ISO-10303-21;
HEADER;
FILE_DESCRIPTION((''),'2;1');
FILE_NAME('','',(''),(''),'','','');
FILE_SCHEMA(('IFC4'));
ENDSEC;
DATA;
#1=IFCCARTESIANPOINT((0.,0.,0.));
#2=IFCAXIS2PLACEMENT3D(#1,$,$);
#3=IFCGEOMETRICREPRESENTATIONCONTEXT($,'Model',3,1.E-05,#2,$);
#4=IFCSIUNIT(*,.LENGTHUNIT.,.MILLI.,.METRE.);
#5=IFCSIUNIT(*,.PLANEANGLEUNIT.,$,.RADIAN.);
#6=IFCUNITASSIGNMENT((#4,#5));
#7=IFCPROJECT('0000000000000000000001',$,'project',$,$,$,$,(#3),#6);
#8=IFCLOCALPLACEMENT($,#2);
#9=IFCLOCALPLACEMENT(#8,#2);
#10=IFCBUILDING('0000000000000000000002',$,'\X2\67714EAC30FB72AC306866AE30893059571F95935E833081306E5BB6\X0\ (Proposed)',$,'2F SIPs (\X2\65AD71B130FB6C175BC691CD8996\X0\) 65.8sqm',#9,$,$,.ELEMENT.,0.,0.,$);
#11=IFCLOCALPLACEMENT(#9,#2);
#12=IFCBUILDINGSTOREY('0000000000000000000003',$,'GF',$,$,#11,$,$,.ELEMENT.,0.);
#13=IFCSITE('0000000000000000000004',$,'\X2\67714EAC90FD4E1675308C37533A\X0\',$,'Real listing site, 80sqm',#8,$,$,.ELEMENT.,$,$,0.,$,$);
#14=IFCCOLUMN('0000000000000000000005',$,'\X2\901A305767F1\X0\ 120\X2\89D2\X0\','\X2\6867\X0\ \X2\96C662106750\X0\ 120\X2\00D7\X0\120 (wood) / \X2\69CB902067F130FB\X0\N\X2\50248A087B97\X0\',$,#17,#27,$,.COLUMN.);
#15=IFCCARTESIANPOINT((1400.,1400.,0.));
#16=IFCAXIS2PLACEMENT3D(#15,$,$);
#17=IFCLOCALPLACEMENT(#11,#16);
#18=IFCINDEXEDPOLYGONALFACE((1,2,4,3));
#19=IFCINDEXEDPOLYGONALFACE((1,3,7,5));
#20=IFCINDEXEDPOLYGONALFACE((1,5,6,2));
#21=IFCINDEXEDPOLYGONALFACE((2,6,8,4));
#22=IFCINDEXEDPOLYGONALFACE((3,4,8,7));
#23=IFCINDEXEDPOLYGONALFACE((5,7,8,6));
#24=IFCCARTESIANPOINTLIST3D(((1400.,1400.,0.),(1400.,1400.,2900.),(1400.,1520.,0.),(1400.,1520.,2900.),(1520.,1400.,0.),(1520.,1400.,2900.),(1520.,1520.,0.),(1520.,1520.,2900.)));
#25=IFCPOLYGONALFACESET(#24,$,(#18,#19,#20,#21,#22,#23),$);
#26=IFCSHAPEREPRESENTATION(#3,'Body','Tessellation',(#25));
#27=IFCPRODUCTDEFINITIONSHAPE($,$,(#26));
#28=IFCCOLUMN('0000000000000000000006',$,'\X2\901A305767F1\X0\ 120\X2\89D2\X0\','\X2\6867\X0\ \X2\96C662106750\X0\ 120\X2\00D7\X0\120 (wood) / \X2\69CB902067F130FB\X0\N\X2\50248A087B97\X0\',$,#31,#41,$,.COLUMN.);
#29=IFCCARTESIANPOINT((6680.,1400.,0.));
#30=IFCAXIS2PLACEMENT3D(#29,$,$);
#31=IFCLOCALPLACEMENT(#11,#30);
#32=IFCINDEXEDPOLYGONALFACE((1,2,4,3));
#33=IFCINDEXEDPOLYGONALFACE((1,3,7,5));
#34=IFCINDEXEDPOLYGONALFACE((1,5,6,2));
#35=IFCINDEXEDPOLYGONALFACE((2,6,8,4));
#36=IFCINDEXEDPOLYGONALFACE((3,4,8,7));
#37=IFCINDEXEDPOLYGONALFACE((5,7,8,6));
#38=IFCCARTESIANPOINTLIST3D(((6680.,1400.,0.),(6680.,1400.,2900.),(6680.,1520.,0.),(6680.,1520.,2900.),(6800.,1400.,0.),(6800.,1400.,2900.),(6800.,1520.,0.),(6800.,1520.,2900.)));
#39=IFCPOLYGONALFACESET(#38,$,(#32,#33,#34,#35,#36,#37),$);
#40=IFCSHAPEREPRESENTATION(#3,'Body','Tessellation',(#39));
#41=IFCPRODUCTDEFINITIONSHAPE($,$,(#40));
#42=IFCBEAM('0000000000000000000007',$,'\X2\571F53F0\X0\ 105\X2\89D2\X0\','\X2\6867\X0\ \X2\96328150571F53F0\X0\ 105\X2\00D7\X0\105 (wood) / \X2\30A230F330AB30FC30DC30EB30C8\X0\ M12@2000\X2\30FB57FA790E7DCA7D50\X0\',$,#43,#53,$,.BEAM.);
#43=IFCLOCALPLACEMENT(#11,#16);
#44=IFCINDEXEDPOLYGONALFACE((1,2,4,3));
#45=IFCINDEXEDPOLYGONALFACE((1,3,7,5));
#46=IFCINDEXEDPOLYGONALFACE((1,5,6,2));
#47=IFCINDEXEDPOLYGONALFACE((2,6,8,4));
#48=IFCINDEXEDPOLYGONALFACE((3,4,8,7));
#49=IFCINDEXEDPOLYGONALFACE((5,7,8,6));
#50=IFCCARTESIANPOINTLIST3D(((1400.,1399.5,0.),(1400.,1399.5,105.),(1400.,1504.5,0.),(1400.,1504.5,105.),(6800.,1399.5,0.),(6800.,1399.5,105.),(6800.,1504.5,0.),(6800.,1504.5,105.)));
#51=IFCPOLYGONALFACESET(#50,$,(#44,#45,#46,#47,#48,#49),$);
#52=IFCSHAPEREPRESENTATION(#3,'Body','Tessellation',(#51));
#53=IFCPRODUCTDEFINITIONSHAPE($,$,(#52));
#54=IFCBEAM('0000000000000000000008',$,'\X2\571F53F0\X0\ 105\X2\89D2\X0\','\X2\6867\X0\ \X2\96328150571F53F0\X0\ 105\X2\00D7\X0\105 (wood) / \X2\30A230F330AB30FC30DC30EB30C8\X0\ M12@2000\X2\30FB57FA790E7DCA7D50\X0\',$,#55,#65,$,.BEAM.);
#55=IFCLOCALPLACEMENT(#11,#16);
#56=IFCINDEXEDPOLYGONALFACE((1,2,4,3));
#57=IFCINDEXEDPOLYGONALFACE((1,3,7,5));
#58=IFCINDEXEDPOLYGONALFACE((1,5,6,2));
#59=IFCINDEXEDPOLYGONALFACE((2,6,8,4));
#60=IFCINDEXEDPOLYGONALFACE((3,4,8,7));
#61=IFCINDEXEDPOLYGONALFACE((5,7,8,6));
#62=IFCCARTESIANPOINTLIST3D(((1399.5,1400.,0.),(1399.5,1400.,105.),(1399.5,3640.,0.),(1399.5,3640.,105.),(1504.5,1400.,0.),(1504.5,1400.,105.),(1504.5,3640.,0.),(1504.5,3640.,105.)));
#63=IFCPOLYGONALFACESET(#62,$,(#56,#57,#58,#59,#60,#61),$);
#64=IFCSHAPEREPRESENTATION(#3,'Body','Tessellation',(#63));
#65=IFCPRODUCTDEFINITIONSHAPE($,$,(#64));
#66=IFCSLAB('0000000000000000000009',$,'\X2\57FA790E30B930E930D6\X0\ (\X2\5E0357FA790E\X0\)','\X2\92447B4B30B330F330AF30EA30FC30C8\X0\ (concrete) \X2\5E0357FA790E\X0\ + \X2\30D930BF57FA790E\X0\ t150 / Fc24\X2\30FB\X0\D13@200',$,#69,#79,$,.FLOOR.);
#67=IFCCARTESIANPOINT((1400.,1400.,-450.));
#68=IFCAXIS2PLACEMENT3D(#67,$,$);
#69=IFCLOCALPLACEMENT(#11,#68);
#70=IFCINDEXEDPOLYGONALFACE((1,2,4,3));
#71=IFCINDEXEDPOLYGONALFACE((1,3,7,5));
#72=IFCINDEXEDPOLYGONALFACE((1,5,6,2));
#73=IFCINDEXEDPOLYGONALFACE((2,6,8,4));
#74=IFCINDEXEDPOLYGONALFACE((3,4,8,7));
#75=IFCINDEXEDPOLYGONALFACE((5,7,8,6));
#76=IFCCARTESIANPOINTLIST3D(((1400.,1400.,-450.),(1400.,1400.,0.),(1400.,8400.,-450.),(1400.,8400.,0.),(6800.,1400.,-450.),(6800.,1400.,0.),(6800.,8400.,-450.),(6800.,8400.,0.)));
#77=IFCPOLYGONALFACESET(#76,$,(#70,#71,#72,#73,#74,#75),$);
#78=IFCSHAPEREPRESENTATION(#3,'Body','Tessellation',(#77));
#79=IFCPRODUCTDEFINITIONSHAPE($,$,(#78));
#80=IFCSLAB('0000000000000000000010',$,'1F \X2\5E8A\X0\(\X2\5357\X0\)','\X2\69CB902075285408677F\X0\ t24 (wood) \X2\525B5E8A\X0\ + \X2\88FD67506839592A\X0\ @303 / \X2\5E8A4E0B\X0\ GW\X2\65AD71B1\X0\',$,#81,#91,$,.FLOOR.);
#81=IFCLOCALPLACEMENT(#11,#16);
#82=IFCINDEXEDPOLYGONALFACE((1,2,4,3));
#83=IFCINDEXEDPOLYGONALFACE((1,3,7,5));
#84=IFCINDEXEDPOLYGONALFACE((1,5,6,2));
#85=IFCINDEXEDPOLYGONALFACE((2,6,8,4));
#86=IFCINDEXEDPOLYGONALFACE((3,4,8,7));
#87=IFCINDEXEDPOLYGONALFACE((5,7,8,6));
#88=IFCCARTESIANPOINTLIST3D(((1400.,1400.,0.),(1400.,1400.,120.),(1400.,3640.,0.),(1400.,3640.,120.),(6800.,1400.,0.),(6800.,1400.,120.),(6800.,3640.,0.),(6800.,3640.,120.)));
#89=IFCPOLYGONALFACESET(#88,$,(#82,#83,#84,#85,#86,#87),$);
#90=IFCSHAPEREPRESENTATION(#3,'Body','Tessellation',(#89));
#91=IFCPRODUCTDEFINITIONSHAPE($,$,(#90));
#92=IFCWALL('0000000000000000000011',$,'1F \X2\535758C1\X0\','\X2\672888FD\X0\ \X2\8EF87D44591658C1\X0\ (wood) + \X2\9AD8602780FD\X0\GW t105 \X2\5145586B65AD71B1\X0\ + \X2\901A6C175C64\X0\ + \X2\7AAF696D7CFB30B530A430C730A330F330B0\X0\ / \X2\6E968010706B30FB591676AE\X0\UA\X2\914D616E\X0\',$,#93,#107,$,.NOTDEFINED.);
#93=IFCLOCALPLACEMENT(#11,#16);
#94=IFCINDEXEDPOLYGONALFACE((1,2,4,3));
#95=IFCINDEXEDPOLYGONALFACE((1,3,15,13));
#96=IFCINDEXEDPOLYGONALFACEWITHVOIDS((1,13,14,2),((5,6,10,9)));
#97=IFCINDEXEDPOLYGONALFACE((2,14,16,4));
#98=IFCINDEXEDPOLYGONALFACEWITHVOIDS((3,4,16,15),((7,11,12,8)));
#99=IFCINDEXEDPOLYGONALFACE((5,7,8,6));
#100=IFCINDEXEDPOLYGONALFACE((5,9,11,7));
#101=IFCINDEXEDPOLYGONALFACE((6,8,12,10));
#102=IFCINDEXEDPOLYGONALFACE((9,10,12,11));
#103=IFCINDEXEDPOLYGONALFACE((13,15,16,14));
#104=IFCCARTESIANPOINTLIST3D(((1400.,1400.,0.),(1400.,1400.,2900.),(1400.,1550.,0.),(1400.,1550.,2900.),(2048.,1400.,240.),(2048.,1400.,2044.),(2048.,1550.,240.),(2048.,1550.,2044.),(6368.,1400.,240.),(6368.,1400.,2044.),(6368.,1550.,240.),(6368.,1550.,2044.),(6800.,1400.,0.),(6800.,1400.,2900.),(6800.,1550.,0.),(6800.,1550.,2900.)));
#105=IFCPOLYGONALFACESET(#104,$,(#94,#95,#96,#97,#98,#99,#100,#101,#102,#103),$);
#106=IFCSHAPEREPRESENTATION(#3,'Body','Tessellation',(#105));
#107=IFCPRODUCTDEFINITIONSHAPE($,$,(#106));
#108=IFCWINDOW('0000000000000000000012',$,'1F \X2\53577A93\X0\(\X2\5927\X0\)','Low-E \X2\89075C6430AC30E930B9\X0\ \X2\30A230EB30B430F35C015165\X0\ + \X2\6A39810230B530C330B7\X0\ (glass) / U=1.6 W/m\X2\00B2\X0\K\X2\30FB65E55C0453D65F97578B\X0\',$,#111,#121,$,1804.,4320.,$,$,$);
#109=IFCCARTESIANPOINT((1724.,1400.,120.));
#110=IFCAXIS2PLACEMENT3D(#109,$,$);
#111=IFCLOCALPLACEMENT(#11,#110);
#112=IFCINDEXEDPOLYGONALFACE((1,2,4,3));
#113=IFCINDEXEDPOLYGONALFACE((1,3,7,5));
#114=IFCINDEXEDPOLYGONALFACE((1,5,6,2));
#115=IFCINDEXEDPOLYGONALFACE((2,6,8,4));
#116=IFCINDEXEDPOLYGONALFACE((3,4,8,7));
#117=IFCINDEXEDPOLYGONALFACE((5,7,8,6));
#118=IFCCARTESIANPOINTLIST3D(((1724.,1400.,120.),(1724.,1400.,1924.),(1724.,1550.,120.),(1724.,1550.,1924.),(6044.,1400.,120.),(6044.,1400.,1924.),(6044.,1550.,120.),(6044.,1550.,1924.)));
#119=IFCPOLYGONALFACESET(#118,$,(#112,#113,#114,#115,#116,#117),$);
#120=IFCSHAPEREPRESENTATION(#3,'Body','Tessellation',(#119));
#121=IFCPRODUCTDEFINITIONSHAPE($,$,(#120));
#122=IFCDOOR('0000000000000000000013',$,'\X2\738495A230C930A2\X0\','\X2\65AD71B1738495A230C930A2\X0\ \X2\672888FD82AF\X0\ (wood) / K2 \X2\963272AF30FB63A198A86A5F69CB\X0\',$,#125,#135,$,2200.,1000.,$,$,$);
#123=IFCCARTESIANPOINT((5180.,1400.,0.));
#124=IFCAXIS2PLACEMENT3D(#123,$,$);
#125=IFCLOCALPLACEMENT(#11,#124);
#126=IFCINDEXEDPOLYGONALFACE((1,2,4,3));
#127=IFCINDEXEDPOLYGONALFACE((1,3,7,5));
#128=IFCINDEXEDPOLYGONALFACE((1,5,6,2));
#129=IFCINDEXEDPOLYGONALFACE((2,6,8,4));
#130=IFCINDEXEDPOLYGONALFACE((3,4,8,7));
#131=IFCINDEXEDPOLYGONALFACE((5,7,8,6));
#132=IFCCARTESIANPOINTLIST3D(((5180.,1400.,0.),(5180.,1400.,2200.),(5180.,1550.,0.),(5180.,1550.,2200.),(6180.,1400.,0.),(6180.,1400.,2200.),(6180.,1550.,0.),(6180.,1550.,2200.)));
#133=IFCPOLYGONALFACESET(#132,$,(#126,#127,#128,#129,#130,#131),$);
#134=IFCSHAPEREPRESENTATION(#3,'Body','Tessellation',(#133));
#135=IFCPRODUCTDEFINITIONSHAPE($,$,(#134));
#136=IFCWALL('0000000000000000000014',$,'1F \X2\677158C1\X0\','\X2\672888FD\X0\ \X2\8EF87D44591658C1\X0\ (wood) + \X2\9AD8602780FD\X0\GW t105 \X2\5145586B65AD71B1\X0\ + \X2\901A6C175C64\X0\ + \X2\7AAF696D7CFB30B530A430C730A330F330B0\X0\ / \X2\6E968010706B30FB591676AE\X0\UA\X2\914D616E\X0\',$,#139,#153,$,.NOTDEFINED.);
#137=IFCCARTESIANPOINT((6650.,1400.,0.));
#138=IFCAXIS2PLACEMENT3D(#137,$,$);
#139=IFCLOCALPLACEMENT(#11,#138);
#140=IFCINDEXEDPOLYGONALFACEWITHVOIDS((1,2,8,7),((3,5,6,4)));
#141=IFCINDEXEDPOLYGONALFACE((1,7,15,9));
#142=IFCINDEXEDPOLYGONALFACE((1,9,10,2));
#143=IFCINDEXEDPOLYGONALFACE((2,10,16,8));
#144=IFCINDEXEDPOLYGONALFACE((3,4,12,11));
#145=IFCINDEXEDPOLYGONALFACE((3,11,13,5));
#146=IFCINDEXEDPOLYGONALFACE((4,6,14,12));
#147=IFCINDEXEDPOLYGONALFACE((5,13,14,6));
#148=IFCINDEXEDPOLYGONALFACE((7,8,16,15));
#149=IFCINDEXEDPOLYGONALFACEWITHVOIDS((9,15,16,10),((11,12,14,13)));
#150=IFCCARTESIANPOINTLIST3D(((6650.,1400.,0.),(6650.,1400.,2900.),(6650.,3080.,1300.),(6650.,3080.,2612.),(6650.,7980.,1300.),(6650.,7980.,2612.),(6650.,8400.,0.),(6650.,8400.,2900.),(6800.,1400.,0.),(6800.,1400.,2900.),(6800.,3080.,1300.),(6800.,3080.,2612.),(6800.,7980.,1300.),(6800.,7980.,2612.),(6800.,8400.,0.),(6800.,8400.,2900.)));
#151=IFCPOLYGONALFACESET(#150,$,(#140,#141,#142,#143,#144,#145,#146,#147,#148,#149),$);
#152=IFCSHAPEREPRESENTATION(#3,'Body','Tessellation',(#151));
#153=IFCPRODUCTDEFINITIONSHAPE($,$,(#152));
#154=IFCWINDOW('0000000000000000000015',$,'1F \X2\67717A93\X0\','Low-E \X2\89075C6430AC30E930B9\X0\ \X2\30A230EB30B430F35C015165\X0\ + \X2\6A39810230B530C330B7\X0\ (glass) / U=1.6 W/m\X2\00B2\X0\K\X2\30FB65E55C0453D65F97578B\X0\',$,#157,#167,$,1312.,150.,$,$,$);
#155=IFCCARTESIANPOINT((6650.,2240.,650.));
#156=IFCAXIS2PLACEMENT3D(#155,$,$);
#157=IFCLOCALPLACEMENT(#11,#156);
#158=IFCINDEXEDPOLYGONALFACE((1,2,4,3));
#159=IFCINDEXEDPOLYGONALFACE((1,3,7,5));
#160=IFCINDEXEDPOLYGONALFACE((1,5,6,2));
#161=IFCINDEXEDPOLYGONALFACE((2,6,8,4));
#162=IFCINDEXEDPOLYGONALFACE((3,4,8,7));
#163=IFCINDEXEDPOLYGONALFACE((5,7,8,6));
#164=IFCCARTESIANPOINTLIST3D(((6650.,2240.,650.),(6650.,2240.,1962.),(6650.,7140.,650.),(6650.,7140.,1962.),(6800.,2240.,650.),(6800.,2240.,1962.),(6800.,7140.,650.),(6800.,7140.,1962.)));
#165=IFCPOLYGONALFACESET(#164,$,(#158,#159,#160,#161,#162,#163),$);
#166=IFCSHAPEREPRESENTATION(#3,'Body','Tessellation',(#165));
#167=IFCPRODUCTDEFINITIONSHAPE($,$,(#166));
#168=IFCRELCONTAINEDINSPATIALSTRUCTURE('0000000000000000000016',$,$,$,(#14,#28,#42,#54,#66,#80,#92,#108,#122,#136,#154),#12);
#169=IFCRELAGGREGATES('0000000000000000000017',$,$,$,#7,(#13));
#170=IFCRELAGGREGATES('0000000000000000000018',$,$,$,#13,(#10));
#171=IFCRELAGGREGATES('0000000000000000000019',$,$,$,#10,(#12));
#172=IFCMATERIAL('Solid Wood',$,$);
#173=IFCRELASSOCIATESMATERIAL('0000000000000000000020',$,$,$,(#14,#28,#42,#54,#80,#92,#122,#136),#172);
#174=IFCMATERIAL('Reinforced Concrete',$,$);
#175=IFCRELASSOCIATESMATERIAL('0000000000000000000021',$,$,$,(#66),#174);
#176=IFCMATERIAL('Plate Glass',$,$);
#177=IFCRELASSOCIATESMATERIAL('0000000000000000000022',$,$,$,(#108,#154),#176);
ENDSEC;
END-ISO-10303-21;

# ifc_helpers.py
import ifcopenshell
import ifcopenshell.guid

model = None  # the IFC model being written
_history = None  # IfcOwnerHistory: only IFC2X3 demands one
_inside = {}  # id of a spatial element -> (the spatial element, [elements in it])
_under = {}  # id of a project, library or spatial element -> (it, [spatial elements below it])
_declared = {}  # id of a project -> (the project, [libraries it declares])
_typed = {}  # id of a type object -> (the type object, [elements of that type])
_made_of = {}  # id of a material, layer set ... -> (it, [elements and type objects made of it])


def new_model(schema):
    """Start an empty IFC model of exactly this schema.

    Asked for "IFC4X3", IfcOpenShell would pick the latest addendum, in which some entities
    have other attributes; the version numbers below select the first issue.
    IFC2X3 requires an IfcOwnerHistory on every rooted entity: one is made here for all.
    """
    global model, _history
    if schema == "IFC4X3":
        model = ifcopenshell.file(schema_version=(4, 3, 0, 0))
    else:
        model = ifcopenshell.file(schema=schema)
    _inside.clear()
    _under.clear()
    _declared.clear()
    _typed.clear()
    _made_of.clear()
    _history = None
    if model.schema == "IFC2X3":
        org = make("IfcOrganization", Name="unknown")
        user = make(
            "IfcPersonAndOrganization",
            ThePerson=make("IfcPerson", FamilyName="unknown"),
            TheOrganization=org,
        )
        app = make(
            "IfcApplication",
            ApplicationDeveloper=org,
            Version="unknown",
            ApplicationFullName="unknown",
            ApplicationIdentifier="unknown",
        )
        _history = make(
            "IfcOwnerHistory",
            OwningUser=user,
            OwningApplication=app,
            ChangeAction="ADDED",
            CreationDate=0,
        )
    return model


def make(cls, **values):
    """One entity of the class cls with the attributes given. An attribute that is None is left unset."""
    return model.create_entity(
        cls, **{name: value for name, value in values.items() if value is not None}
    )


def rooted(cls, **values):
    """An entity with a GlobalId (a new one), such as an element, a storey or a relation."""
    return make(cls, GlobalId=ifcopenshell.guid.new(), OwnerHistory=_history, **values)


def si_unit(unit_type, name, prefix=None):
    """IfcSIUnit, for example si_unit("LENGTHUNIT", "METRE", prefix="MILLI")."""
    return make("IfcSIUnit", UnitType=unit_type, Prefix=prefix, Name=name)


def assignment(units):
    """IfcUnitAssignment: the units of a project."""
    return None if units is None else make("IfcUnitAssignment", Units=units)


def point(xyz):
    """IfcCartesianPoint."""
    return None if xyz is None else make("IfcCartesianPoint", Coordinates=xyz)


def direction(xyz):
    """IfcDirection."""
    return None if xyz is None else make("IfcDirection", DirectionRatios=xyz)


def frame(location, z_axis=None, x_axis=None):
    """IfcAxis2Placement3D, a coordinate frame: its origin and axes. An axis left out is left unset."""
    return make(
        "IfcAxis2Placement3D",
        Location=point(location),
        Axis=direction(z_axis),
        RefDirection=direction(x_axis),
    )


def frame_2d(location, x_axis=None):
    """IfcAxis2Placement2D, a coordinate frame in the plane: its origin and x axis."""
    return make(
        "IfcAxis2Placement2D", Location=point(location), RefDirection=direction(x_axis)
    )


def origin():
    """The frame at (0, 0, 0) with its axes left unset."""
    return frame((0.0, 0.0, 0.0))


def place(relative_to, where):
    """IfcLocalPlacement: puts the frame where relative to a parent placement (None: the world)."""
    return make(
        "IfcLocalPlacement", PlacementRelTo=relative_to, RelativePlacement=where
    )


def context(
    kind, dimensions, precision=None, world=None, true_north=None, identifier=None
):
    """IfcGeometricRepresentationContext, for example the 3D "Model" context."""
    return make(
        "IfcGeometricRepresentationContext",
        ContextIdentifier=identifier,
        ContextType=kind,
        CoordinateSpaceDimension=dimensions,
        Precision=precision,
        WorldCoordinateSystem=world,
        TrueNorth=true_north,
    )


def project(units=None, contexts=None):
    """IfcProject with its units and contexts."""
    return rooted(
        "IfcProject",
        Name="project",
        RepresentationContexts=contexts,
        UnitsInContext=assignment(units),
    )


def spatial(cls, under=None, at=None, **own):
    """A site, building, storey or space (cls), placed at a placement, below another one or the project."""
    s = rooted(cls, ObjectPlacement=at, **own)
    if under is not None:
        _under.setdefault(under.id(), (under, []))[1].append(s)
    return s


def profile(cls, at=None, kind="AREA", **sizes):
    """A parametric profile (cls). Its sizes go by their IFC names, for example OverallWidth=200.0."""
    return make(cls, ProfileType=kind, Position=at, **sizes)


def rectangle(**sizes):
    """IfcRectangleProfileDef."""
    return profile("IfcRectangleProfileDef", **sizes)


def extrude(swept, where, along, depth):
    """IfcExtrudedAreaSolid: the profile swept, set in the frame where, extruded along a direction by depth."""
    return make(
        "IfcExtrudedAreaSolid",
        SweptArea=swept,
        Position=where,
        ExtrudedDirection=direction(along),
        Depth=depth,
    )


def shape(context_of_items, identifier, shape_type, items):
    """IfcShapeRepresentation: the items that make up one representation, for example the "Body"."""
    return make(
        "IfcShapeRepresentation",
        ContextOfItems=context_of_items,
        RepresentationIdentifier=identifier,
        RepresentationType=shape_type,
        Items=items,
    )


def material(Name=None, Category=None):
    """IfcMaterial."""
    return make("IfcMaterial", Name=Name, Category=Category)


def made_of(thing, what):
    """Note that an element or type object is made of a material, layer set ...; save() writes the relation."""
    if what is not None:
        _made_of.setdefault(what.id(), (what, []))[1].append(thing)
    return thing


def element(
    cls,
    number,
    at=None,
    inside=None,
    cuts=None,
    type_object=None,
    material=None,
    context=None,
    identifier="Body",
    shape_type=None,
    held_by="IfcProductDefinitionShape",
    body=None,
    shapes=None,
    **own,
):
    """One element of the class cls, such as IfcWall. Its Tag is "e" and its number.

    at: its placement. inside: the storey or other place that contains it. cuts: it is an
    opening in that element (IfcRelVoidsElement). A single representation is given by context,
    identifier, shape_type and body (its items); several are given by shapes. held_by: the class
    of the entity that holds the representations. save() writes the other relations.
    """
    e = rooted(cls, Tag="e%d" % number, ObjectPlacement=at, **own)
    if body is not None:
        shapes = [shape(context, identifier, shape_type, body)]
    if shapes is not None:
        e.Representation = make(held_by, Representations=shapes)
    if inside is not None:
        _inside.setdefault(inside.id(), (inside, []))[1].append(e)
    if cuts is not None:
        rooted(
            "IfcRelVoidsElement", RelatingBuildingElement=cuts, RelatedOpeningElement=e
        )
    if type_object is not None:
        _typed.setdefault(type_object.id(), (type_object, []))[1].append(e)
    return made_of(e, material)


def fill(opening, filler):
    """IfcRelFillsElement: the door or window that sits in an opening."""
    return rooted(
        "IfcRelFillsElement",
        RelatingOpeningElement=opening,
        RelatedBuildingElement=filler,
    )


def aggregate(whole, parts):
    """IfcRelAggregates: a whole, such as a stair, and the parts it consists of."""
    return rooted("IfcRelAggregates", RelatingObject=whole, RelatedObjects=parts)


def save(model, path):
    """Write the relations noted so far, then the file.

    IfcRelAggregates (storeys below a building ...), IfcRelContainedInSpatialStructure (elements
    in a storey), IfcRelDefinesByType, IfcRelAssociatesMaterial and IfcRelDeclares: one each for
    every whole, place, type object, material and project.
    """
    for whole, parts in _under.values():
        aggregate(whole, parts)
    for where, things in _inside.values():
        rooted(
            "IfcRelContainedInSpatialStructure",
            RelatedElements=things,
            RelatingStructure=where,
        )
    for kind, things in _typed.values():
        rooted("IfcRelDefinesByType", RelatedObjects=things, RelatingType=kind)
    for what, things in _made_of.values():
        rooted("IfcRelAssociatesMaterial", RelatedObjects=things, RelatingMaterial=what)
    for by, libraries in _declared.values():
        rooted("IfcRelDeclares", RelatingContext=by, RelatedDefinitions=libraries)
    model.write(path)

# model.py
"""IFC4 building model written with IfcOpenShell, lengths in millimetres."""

from ifc_helpers import new_model, si_unit, frame, frame_2d, origin, place, context, project, spatial, rectangle, extrude, material, element, fill, save


model = new_model("IFC4")

# Units and contexts
model_context = context("Model", 3, precision=1e-05, world=origin())
ifc_project = project(units=[si_unit("LENGTHUNIT", "METRE", prefix="MILLI"), si_unit("PLANEANGLEUNIT", "RADIAN")], contexts=[model_context])

# Site, building, storey
site_placement = place(None, origin())
site = spatial("IfcSite", under=ifc_project, at=site_placement, Name="東京都世田谷区", ObjectType="Real listing site, 80sqm", CompositionType="ELEMENT", RefElevation=0.0)
building_placement = place(site_placement, origin())
building = spatial("IfcBuilding", under=site, at=building_placement, Name="東京・犬と暮らす土間広めの家 (Proposed)", ObjectType="2F SIPs (断熱・気密重視) 65.8sqm", CompositionType="ELEMENT", ElevationOfRefHeight=0.0, ElevationOfTerrain=0.0)
storey_placement = place(building_placement, origin())
storey = spatial("IfcBuildingStorey", under=building, at=storey_placement, Name="GF", CompositionType="ELEMENT", Elevation=0.0)

# Columns
ifc_material_1 = material(Name="Solid Wood")
column_1_placement = place(storey_placement, frame((1400.0, 1400.0, 0.0)))
element("IfcColumn", 1, at=column_1_placement, inside=storey, material=ifc_material_1, Name="通し柱 120角", Description="桧 集成材 120×120 (wood) / 構造柱・N値計算", PredefinedType="COLUMN", context=model_context, shape_type="SweptSolid", body=[
    extrude(rectangle(XDim=120.0, YDim=120.0, at=frame_2d((60.0, 60.0))), frame((1400.0, 1400.0, 0.0)), (0.0, 0.0, 1.0), 2900.0),
])
column_2_placement = place(storey_placement, frame((6680.0, 1400.0, 0.0)))
element("IfcColumn", 2, at=column_2_placement, inside=storey, material=ifc_material_1, Name="通し柱 120角", Description="桧 集成材 120×120 (wood) / 構造柱・N値計算", PredefinedType="COLUMN", context=model_context, shape_type="SweptSolid", body=[
    extrude(rectangle(XDim=120.0, YDim=120.0, at=frame_2d((60.0, 60.0))), frame((6680.0, 1400.0, 0.0)), (0.0, 0.0, 1.0), 2900.0),
])

# Beams
beam_1_placement = place(storey_placement, frame((1400.0, 1400.0, 0.0)))
element("IfcBeam", 3, at=beam_1_placement, inside=storey, material=ifc_material_1, Name="土台 105角", Description="桧 防腐土台 105×105 (wood) / アンカーボルト M12@2000・基礎緊結", PredefinedType="BEAM", context=model_context, shape_type="SweptSolid", body=[
    extrude(rectangle(XDim=5400.0, YDim=105.0, at=frame_2d((2700.0, 52.0))), frame((1400.0, 1400.0, 0.0)), (0.0, 0.0, 1.0), 105.0),
])
beam_2_placement = place(storey_placement, frame((1400.0, 1400.0, 0.0)))
element("IfcBeam", 4, at=beam_2_placement, inside=storey, material=ifc_material_1, Name="土台 105角", Description="桧 防腐土台 105×105 (wood) / アンカーボルト M12@2000・基礎緊結", PredefinedType="BEAM", context=model_context, shape_type="SweptSolid", body=[
    extrude(rectangle(XDim=105.0, YDim=2240.0, at=frame_2d((52.0, 1120.0))), frame((1400.0, 1400.0, 0.0)), (0.0, 0.0, 1.0), 105.0),
])

# Slabs
ifc_material_2 = material(Name="Reinforced Concrete")
slab_1_placement = place(storey_placement, frame((1400.0, 1400.0, -450.0)))
element("IfcSlab", 5, at=slab_1_placement, inside=storey, material=ifc_material_2, Name="基礎スラブ (布基礎)", Description="鉄筋コンクリート (concrete) 布基礎 + ベタ基礎 t150 / Fc24・D13@200", PredefinedType="FLOOR", context=model_context, shape_type="SweptSolid", body=[
    extrude(rectangle(XDim=5400.0, YDim=7000.0, at=frame_2d((2700.0, 3500.0))), frame((1400.0, 1400.0, -450.0)), (0.0, 0.0, 1.0), 450.0),
])
slab_2_placement = place(storey_placement, frame((1400.0, 1400.0, 0.0)))
element("IfcSlab", 6, at=slab_2_placement, inside=storey, material=ifc_material_1, Name="1F 床(南)", Description="構造用合板 t24 (wood) 剛床 + 製材根太 @303 / 床下 GW断熱", PredefinedType="FLOOR", context=model_context, shape_type="SweptSolid", body=[
    extrude(rectangle(XDim=5400.0, YDim=2240.0, at=frame_2d((2700.0, 1120.0))), frame((1400.0, 1400.0, 0.0)), (0.0, 0.0, 1.0), 120.0),
])

# Wall, openings, window, door
wall_1_placement = place(storey_placement, frame((1400.0, 1400.0, 0.0)))
wall_1 = element("IfcWall", 7, at=wall_1_placement, inside=storey, material=ifc_material_1, Name="1F 南壁", Description="木製 軸組外壁 (wood) + 高性能GW t105 充填断熱 + 通気層 + 窯業系サイディング / 準耐火・外皮UA配慮", PredefinedType="NOTDEFINED", context=model_context, shape_type="SweptSolid", body=[
    extrude(rectangle(XDim=5400.0, YDim=150.0, at=frame_2d((2700.0, 75.0))), frame((1400.0, 1400.0, 0.0)), (0.0, 0.0, 1.0), 2900.0),
])
opening_1_placement = place(storey_placement, frame((1724.0, 1400.0, 120.0)))
opening_1 = element("IfcOpeningElement", 8, at=opening_1_placement, cuts=wall_1, PredefinedType="NOTDEFINED", context=model_context, shape_type="SweptSolid", body=[
    extrude(rectangle(XDim=4320.0, YDim=150.0, at=frame_2d((2160.0, 75.0))), frame((1724.0, 1400.0, 120.0)), (0.0, 0.0, 1.0), 1804.0),
])
opening_2_placement = place(storey_placement, frame((5180.0, 1400.0, 0.0)))
opening_2 = element("IfcOpeningElement", 9, at=opening_2_placement, cuts=wall_1, PredefinedType="NOTDEFINED", context=model_context, shape_type="SweptSolid", body=[
    extrude(rectangle(XDim=1000.0, YDim=150.0, at=frame_2d((500.0, 75.0))), frame((5180.0, 1400.0, 0.0)), (0.0, 0.0, 1.0), 2200.0),
])
ifc_material_3 = material(Name="Plate Glass")
window_1_placement = place(storey_placement, frame((1724.0, 1400.0, 120.0)))
window_1 = element("IfcWindow", 10, at=window_1_placement, inside=storey, material=ifc_material_3, Name="1F 南窓(大)", Description="Low-E 複層ガラス アルゴン封入 + 樹脂サッシ (glass) / U=1.6 W/m²K・日射取得型", OverallHeight=1804.0, OverallWidth=4320.0, context=model_context, shape_type="SweptSolid", body=[
    extrude(rectangle(XDim=4320.0, YDim=150.0, at=frame_2d((2160.0, 75.0))), frame((1724.0, 1400.0, 120.0)), (0.0, 0.0, 1.0), 1804.0),
])
fill(opening_1, window_1)
door_placement = place(storey_placement, frame((5180.0, 1400.0, 0.0)))
door = element("IfcDoor", 11, at=door_placement, inside=storey, material=ifc_material_1, Name="玄関ドア", Description="断熱玄関ドア 木製芯 (wood) / K2 防犯・採風機構", OverallHeight=2200.0, OverallWidth=1000.0, context=model_context, shape_type="SweptSolid", body=[
    extrude(rectangle(XDim=1000.0, YDim=150.0, at=frame_2d((500.0, 75.0))), frame((5180.0, 1400.0, 0.0)), (0.0, 0.0, 1.0), 2200.0),
])
fill(opening_2, door)

# Wall, opening, window
wall_2_placement = place(storey_placement, frame((6650.0, 1400.0, 0.0)))
wall_2 = element("IfcWall", 12, at=wall_2_placement, inside=storey, material=ifc_material_1, Name="1F 東壁", Description="木製 軸組外壁 (wood) + 高性能GW t105 充填断熱 + 通気層 + 窯業系サイディング / 準耐火・外皮UA配慮", PredefinedType="NOTDEFINED", context=model_context, shape_type="SweptSolid", body=[
    extrude(rectangle(XDim=150.0, YDim=7000.0, at=frame_2d((75.0, 3500.0))), frame((6650.0, 1400.0, 0.0)), (0.0, 0.0, 1.0), 2900.0),
])
opening_3_placement = place(storey_placement, frame((6650.0, 2240.0, 650.0)))
opening_3 = element("IfcOpeningElement", 13, at=opening_3_placement, cuts=wall_2, PredefinedType="NOTDEFINED", context=model_context, shape_type="SweptSolid", body=[
    extrude(rectangle(XDim=150.0, YDim=4900.0, at=frame_2d((75.0, 2450.0))), frame((6650.0, 2240.0, 650.0)), (0.0, 0.0, 1.0), 1312.0),
])
window_2_placement = place(storey_placement, frame((6650.0, 2240.0, 650.0)))
window_2 = element("IfcWindow", 14, at=window_2_placement, inside=storey, material=ifc_material_3, Name="1F 東窓", Description="Low-E 複層ガラス アルゴン封入 + 樹脂サッシ (glass) / U=1.6 W/m²K・日射取得型", OverallHeight=1312.0, OverallWidth=150.0, context=model_context, shape_type="SweptSolid", body=[
    extrude(rectangle(XDim=150.0, YDim=4900.0, at=frame_2d((75.0, 2450.0))), frame((6650.0, 2240.0, 650.0)), (0.0, 0.0, 1.0), 1312.0),
])
fill(opening_3, window_2)

save(model, "model.ifc")
